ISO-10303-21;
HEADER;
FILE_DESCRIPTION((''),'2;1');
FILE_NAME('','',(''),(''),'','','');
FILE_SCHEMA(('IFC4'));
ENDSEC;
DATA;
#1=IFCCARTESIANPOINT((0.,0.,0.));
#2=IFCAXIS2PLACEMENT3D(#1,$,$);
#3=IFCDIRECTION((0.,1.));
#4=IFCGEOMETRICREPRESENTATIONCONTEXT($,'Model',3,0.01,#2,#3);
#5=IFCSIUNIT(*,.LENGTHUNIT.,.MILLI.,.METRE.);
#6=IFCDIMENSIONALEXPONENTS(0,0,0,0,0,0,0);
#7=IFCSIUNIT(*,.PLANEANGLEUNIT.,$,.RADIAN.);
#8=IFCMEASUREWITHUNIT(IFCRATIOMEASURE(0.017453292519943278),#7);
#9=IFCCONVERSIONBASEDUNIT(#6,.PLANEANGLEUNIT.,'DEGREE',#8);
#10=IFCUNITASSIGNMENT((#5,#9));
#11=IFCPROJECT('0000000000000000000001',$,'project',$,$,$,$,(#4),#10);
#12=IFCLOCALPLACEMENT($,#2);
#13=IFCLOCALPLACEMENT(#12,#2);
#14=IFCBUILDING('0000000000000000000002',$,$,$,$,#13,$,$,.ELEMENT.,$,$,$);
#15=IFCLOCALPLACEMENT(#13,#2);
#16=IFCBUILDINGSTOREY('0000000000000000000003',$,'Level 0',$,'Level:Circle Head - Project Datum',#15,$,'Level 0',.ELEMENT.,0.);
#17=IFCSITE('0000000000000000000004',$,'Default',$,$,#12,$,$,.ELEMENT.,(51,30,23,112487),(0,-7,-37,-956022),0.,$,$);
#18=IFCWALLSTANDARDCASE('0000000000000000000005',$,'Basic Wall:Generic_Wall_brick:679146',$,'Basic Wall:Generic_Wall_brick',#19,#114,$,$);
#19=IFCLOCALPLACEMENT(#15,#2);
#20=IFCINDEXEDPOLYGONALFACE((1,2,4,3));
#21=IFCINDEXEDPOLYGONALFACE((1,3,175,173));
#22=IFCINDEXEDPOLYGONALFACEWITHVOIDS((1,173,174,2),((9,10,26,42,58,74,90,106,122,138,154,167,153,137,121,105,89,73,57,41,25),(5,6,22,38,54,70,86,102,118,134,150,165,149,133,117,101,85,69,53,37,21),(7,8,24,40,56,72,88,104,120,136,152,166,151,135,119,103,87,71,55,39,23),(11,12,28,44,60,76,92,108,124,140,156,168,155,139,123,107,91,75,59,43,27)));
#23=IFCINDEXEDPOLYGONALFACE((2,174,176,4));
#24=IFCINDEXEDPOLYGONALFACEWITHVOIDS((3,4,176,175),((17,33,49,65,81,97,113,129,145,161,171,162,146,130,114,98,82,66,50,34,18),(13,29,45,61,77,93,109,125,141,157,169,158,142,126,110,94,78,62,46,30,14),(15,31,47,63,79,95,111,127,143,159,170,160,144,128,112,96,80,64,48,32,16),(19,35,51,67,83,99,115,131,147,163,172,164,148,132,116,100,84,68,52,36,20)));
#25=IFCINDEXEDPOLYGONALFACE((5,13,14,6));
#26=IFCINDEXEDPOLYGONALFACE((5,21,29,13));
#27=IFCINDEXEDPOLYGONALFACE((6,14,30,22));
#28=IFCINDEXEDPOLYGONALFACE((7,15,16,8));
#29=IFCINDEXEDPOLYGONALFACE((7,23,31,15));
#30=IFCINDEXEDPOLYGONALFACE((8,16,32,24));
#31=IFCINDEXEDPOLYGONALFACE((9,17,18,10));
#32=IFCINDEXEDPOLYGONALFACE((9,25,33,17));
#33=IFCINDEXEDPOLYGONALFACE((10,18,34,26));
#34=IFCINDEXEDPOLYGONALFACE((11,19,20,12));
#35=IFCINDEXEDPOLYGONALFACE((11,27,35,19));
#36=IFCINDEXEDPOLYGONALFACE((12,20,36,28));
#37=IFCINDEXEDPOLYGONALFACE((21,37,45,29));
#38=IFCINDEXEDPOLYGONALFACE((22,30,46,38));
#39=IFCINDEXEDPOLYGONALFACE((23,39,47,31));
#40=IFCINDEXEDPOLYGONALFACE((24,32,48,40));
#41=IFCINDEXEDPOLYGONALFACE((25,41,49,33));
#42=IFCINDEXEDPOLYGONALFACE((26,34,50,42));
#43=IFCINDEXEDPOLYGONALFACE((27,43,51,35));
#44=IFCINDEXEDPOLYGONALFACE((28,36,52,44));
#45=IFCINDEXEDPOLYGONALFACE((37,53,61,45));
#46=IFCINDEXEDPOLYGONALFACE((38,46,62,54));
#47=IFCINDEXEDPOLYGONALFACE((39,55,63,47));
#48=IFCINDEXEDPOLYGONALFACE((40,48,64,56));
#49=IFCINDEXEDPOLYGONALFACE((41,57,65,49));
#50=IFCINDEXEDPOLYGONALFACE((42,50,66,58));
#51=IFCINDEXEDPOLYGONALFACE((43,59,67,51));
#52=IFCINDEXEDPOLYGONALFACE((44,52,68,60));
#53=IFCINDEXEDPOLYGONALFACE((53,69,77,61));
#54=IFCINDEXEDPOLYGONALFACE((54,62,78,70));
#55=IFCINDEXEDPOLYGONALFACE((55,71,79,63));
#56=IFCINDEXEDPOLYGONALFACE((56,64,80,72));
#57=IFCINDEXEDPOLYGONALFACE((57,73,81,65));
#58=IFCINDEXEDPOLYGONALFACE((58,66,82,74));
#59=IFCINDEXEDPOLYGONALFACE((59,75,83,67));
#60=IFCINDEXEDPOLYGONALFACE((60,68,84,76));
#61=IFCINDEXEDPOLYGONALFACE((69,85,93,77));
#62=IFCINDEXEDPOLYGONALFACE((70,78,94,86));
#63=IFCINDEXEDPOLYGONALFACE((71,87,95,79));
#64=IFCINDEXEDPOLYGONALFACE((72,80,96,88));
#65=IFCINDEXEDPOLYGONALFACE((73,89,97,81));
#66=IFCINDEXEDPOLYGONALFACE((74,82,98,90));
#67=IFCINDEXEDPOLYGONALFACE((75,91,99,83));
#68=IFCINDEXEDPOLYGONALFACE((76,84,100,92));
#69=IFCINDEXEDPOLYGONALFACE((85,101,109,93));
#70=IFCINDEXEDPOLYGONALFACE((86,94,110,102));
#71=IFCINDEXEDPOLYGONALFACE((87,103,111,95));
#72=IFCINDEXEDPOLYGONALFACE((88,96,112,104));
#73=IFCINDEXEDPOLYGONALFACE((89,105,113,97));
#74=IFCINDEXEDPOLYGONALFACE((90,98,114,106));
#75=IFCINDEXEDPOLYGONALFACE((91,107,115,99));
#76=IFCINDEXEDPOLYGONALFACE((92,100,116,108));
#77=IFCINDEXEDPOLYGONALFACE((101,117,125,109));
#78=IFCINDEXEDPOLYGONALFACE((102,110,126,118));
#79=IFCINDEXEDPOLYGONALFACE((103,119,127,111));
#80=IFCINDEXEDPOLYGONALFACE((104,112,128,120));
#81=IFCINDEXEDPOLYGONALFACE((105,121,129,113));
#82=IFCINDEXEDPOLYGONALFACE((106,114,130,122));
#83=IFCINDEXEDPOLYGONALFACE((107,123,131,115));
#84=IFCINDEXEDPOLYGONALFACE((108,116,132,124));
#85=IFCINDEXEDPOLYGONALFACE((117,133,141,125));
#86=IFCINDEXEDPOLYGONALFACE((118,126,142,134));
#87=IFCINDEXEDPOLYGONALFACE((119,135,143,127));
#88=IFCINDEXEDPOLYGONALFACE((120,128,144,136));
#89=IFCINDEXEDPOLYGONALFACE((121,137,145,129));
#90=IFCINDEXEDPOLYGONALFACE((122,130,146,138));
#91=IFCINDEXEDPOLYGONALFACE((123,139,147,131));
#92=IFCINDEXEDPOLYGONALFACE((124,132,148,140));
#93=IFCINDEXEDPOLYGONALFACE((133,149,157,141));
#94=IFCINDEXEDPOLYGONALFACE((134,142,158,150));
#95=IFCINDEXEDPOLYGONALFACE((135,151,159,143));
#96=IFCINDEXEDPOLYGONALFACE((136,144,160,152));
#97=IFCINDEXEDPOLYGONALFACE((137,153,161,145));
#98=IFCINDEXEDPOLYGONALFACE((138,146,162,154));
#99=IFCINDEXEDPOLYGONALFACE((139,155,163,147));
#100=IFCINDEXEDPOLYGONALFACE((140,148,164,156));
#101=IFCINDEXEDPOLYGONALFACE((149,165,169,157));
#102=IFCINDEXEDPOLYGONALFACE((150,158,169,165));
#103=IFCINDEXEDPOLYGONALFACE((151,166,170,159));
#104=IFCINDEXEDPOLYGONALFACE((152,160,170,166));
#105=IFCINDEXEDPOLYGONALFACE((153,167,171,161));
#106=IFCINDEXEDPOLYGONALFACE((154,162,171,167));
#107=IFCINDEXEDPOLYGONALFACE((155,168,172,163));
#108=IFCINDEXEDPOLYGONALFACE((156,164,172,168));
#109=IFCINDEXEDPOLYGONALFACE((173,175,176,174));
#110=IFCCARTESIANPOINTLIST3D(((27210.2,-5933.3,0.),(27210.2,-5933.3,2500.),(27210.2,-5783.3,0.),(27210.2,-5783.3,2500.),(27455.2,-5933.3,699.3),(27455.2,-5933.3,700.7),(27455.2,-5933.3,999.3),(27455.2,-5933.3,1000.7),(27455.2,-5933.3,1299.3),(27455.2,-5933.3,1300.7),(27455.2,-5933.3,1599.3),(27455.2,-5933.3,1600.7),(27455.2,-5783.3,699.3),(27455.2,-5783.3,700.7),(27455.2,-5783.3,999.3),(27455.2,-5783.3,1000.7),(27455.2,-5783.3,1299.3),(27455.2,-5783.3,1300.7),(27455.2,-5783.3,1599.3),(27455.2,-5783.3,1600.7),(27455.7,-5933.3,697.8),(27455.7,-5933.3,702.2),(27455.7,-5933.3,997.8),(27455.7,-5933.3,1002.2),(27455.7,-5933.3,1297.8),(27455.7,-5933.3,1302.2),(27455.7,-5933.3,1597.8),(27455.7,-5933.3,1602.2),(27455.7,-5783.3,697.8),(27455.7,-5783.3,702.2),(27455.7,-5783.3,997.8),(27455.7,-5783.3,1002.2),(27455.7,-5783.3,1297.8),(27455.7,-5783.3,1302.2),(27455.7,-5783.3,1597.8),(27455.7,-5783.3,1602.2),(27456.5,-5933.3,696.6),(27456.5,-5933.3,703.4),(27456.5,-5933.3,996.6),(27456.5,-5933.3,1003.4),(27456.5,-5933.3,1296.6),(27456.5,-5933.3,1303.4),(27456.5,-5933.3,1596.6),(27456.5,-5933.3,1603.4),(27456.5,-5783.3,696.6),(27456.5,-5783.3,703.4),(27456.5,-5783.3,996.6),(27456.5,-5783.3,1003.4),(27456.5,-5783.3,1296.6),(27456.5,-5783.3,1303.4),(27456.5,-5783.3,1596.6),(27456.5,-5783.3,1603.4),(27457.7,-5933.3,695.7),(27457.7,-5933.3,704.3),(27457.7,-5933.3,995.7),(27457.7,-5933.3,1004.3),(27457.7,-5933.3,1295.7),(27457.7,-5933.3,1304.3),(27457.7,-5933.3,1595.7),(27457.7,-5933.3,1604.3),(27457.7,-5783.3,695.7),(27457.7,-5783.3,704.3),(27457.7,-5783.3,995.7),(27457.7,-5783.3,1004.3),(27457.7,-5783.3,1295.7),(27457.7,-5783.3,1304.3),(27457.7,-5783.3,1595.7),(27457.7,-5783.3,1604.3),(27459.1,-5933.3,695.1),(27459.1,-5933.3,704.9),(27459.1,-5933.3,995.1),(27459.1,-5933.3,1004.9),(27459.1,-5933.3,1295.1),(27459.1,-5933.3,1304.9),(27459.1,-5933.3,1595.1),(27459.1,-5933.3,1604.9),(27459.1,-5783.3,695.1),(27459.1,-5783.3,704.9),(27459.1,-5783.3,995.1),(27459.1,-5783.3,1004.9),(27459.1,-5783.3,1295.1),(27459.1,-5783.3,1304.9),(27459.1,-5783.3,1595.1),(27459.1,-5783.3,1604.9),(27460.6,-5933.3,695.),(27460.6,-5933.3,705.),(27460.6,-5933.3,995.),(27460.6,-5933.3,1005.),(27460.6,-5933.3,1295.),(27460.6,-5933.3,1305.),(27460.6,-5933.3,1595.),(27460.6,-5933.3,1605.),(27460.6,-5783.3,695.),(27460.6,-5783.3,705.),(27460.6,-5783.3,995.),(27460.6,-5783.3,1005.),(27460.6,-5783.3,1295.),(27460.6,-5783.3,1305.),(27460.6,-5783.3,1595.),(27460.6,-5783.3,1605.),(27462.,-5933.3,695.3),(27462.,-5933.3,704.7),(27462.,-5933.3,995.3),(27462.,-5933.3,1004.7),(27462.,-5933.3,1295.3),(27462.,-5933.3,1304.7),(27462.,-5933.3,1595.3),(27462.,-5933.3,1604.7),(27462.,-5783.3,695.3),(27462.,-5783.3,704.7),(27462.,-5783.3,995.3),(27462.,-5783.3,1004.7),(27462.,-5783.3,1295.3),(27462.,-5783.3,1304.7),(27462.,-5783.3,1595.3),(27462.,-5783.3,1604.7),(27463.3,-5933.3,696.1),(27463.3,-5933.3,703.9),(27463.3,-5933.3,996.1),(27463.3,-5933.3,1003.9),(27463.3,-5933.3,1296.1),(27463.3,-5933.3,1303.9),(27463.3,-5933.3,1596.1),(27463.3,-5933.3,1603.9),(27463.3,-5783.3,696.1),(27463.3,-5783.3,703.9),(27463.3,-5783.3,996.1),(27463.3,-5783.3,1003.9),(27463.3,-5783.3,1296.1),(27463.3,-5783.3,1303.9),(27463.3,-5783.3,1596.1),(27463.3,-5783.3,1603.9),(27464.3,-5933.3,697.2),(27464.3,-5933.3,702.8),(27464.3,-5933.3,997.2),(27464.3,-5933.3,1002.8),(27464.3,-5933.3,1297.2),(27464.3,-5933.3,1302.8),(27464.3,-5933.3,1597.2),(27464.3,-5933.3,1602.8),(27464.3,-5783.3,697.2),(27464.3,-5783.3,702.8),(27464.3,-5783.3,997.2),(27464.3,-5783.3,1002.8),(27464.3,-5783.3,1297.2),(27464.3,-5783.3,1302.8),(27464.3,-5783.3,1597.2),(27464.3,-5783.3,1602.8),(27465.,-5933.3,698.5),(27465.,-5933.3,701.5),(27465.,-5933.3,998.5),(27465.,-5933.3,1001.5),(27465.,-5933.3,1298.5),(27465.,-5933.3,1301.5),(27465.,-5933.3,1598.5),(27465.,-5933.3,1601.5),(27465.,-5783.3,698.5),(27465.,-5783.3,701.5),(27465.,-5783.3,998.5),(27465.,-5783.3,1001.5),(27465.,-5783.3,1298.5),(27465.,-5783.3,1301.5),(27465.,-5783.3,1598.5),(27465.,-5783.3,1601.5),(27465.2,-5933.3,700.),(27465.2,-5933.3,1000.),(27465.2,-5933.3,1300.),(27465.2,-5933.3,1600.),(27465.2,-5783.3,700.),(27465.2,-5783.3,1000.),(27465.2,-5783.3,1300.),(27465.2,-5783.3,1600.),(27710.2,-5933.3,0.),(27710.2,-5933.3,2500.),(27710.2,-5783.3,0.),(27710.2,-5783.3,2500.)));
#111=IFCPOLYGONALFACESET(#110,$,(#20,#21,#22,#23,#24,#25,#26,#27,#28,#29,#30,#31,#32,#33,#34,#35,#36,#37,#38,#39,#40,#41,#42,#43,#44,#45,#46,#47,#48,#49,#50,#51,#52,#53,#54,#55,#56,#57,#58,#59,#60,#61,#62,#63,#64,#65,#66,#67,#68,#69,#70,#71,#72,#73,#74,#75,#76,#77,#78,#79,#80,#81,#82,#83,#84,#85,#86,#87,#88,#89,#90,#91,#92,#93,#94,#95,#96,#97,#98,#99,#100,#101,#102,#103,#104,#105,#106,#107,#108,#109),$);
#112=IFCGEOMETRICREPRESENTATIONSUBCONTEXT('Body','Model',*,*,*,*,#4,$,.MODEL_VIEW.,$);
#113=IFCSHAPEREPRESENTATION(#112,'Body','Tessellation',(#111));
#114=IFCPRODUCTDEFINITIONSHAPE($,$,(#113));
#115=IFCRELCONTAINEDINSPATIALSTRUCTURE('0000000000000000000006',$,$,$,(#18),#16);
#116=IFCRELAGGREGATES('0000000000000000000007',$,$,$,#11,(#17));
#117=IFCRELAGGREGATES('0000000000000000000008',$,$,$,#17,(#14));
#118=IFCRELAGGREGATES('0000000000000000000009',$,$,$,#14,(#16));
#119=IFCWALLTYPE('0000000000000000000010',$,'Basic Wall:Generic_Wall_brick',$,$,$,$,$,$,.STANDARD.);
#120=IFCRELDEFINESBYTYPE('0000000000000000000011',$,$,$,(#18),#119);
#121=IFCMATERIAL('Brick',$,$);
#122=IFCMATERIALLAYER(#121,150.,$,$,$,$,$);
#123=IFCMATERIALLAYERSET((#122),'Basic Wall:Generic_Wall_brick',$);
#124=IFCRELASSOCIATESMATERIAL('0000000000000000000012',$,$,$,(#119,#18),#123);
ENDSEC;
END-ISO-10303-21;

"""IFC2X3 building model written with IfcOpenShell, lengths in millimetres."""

from ifc_helpers import new_model, entity, si_unit, converted_unit, direction, frame, frame_2d, origin, origin_2d_with_axis, place, context, subcontext, project, spatial, rectangle, circle, extrude, material, layer, layer_set, layer_usage, type_object, element, save


model = new_model("IFC2X3")

# Units and contexts
model_context = context("Model", 3, precision=0.01, world=origin(), true_north=direction((0.0, 1.0)))
body_context = subcontext(model_context, "Body", "Model", "MODEL_VIEW")
ifc_project = project(units=[si_unit("LENGTHUNIT", "METRE", prefix="MILLI"), converted_unit("PLANEANGLEUNIT", "DEGREE", entity("IfcRatioMeasure", 0.017453292519943278), si_unit("PLANEANGLEUNIT", "RADIAN"), dimensions=[0, 0, 0, 0, 0, 0, 0])], contexts=[model_context])

# Site, building, storey
site_placement = place(None, origin())
site = spatial("IfcSite", under=ifc_project, at=site_placement, Name="Default", CompositionType="ELEMENT", RefLatitude=(51, 30, 23, 112487), RefLongitude=(0, -7, -37, -956022), RefElevation=0.0)
building_placement = place(site_placement, origin())
building = spatial("IfcBuilding", under=site, at=building_placement, CompositionType="ELEMENT")
storey_placement = place(building_placement, origin())
storey = spatial("IfcBuildingStorey", under=building, at=storey_placement, Name="Level 0", ObjectType="Level:Circle Head - Project Datum", LongName="Level 0", CompositionType="ELEMENT", Elevation=0.0)

# Wall, openings
ifc_material_1 = material(Name="Brick")
ifc_layer_1 = layer(ifc_material_1, 150.0)
ifc_layer_set_1 = layer_set([ifc_layer_1], Name="Basic Wall:Generic_Wall_brick")
ifc_layer_usage_1 = layer_usage(ifc_layer_set_1, "AXIS2", "NEGATIVE", 75.0)
wall_type_1 = type_object("IfcWallType", Name="Basic Wall:Generic_Wall_brick", PredefinedType="STANDARD", material=ifc_layer_set_1)
wall_1_placement = place(storey_placement, frame((27710.2, -5858.3, 0.0), z_axis=(0.0, 0.0, 1.0), x_axis=(-1.0, 0.0, 0.0)))
wall_1 = element("IfcWallStandardCase", 1, at=wall_1_placement, inside=storey, type_object=wall_type_1, material=ifc_layer_usage_1, Name="Basic Wall:Generic_Wall_brick:679146", ObjectType="Basic Wall:Generic_Wall_brick", context=body_context, shape_type="SweptSolid", body=[
    extrude(rectangle(XDim=500.0, YDim=150.0, at=frame_2d((250.0, 0.0), x_axis=(-1.0, 0.0))), origin(), (0.0, 0.0, 1.0), 2500.0),
])
opening_1_placement = place(wall_1_placement, origin())
element("IfcOpeningElement", 2, at=opening_1_placement, cuts=wall_1, ObjectType="Opening", context=body_context, shape_type="SweptSolid", body=[
    extrude(circle(Radius=5.0, at=origin_2d_with_axis()), frame((250.0, -75.0, 700.0), z_axis=(0.0, 1.0, 0.0), x_axis=(-1.0, 0.0, 0.0)), (0.0, 0.0, 1.0), 200.0),
])
opening_2_placement = place(wall_1_placement, origin())
element("IfcOpeningElement", 3, at=opening_2_placement, cuts=wall_1, ObjectType="Opening", context=body_context, shape_type="SweptSolid", body=[
    extrude(circle(Radius=5.0, at=origin_2d_with_axis()), frame((250.0, -75.0, 1000.0), z_axis=(0.0, 1.0, 0.0), x_axis=(-1.0, 0.0, 0.0)), (0.0, 0.0, 1.0), 200.0),
])
opening_3_placement = place(wall_1_placement, origin())
element("IfcOpeningElement", 4, at=opening_3_placement, cuts=wall_1, ObjectType="Opening", context=body_context, shape_type="SweptSolid", body=[
    extrude(circle(Radius=5.0, at=origin_2d_with_axis()), frame((250.0, -75.0, 1300.0), z_axis=(0.0, 1.0, 0.0), x_axis=(-1.0, 0.0, 0.0)), (0.0, 0.0, 1.0), 200.0),
])
opening_4_placement = place(wall_1_placement, origin())
element("IfcOpeningElement", 5, at=opening_4_placement, cuts=wall_1, ObjectType="Opening", context=body_context, shape_type="SweptSolid", body=[
    extrude(circle(Radius=5.0, at=origin_2d_with_axis()), frame((250.0, -75.0, 1600.0), z_axis=(0.0, 1.0, 0.0), x_axis=(-1.0, 0.0, 0.0)), (0.0, 0.0, 1.0), 200.0),
])

save(model, "model.ifc")
